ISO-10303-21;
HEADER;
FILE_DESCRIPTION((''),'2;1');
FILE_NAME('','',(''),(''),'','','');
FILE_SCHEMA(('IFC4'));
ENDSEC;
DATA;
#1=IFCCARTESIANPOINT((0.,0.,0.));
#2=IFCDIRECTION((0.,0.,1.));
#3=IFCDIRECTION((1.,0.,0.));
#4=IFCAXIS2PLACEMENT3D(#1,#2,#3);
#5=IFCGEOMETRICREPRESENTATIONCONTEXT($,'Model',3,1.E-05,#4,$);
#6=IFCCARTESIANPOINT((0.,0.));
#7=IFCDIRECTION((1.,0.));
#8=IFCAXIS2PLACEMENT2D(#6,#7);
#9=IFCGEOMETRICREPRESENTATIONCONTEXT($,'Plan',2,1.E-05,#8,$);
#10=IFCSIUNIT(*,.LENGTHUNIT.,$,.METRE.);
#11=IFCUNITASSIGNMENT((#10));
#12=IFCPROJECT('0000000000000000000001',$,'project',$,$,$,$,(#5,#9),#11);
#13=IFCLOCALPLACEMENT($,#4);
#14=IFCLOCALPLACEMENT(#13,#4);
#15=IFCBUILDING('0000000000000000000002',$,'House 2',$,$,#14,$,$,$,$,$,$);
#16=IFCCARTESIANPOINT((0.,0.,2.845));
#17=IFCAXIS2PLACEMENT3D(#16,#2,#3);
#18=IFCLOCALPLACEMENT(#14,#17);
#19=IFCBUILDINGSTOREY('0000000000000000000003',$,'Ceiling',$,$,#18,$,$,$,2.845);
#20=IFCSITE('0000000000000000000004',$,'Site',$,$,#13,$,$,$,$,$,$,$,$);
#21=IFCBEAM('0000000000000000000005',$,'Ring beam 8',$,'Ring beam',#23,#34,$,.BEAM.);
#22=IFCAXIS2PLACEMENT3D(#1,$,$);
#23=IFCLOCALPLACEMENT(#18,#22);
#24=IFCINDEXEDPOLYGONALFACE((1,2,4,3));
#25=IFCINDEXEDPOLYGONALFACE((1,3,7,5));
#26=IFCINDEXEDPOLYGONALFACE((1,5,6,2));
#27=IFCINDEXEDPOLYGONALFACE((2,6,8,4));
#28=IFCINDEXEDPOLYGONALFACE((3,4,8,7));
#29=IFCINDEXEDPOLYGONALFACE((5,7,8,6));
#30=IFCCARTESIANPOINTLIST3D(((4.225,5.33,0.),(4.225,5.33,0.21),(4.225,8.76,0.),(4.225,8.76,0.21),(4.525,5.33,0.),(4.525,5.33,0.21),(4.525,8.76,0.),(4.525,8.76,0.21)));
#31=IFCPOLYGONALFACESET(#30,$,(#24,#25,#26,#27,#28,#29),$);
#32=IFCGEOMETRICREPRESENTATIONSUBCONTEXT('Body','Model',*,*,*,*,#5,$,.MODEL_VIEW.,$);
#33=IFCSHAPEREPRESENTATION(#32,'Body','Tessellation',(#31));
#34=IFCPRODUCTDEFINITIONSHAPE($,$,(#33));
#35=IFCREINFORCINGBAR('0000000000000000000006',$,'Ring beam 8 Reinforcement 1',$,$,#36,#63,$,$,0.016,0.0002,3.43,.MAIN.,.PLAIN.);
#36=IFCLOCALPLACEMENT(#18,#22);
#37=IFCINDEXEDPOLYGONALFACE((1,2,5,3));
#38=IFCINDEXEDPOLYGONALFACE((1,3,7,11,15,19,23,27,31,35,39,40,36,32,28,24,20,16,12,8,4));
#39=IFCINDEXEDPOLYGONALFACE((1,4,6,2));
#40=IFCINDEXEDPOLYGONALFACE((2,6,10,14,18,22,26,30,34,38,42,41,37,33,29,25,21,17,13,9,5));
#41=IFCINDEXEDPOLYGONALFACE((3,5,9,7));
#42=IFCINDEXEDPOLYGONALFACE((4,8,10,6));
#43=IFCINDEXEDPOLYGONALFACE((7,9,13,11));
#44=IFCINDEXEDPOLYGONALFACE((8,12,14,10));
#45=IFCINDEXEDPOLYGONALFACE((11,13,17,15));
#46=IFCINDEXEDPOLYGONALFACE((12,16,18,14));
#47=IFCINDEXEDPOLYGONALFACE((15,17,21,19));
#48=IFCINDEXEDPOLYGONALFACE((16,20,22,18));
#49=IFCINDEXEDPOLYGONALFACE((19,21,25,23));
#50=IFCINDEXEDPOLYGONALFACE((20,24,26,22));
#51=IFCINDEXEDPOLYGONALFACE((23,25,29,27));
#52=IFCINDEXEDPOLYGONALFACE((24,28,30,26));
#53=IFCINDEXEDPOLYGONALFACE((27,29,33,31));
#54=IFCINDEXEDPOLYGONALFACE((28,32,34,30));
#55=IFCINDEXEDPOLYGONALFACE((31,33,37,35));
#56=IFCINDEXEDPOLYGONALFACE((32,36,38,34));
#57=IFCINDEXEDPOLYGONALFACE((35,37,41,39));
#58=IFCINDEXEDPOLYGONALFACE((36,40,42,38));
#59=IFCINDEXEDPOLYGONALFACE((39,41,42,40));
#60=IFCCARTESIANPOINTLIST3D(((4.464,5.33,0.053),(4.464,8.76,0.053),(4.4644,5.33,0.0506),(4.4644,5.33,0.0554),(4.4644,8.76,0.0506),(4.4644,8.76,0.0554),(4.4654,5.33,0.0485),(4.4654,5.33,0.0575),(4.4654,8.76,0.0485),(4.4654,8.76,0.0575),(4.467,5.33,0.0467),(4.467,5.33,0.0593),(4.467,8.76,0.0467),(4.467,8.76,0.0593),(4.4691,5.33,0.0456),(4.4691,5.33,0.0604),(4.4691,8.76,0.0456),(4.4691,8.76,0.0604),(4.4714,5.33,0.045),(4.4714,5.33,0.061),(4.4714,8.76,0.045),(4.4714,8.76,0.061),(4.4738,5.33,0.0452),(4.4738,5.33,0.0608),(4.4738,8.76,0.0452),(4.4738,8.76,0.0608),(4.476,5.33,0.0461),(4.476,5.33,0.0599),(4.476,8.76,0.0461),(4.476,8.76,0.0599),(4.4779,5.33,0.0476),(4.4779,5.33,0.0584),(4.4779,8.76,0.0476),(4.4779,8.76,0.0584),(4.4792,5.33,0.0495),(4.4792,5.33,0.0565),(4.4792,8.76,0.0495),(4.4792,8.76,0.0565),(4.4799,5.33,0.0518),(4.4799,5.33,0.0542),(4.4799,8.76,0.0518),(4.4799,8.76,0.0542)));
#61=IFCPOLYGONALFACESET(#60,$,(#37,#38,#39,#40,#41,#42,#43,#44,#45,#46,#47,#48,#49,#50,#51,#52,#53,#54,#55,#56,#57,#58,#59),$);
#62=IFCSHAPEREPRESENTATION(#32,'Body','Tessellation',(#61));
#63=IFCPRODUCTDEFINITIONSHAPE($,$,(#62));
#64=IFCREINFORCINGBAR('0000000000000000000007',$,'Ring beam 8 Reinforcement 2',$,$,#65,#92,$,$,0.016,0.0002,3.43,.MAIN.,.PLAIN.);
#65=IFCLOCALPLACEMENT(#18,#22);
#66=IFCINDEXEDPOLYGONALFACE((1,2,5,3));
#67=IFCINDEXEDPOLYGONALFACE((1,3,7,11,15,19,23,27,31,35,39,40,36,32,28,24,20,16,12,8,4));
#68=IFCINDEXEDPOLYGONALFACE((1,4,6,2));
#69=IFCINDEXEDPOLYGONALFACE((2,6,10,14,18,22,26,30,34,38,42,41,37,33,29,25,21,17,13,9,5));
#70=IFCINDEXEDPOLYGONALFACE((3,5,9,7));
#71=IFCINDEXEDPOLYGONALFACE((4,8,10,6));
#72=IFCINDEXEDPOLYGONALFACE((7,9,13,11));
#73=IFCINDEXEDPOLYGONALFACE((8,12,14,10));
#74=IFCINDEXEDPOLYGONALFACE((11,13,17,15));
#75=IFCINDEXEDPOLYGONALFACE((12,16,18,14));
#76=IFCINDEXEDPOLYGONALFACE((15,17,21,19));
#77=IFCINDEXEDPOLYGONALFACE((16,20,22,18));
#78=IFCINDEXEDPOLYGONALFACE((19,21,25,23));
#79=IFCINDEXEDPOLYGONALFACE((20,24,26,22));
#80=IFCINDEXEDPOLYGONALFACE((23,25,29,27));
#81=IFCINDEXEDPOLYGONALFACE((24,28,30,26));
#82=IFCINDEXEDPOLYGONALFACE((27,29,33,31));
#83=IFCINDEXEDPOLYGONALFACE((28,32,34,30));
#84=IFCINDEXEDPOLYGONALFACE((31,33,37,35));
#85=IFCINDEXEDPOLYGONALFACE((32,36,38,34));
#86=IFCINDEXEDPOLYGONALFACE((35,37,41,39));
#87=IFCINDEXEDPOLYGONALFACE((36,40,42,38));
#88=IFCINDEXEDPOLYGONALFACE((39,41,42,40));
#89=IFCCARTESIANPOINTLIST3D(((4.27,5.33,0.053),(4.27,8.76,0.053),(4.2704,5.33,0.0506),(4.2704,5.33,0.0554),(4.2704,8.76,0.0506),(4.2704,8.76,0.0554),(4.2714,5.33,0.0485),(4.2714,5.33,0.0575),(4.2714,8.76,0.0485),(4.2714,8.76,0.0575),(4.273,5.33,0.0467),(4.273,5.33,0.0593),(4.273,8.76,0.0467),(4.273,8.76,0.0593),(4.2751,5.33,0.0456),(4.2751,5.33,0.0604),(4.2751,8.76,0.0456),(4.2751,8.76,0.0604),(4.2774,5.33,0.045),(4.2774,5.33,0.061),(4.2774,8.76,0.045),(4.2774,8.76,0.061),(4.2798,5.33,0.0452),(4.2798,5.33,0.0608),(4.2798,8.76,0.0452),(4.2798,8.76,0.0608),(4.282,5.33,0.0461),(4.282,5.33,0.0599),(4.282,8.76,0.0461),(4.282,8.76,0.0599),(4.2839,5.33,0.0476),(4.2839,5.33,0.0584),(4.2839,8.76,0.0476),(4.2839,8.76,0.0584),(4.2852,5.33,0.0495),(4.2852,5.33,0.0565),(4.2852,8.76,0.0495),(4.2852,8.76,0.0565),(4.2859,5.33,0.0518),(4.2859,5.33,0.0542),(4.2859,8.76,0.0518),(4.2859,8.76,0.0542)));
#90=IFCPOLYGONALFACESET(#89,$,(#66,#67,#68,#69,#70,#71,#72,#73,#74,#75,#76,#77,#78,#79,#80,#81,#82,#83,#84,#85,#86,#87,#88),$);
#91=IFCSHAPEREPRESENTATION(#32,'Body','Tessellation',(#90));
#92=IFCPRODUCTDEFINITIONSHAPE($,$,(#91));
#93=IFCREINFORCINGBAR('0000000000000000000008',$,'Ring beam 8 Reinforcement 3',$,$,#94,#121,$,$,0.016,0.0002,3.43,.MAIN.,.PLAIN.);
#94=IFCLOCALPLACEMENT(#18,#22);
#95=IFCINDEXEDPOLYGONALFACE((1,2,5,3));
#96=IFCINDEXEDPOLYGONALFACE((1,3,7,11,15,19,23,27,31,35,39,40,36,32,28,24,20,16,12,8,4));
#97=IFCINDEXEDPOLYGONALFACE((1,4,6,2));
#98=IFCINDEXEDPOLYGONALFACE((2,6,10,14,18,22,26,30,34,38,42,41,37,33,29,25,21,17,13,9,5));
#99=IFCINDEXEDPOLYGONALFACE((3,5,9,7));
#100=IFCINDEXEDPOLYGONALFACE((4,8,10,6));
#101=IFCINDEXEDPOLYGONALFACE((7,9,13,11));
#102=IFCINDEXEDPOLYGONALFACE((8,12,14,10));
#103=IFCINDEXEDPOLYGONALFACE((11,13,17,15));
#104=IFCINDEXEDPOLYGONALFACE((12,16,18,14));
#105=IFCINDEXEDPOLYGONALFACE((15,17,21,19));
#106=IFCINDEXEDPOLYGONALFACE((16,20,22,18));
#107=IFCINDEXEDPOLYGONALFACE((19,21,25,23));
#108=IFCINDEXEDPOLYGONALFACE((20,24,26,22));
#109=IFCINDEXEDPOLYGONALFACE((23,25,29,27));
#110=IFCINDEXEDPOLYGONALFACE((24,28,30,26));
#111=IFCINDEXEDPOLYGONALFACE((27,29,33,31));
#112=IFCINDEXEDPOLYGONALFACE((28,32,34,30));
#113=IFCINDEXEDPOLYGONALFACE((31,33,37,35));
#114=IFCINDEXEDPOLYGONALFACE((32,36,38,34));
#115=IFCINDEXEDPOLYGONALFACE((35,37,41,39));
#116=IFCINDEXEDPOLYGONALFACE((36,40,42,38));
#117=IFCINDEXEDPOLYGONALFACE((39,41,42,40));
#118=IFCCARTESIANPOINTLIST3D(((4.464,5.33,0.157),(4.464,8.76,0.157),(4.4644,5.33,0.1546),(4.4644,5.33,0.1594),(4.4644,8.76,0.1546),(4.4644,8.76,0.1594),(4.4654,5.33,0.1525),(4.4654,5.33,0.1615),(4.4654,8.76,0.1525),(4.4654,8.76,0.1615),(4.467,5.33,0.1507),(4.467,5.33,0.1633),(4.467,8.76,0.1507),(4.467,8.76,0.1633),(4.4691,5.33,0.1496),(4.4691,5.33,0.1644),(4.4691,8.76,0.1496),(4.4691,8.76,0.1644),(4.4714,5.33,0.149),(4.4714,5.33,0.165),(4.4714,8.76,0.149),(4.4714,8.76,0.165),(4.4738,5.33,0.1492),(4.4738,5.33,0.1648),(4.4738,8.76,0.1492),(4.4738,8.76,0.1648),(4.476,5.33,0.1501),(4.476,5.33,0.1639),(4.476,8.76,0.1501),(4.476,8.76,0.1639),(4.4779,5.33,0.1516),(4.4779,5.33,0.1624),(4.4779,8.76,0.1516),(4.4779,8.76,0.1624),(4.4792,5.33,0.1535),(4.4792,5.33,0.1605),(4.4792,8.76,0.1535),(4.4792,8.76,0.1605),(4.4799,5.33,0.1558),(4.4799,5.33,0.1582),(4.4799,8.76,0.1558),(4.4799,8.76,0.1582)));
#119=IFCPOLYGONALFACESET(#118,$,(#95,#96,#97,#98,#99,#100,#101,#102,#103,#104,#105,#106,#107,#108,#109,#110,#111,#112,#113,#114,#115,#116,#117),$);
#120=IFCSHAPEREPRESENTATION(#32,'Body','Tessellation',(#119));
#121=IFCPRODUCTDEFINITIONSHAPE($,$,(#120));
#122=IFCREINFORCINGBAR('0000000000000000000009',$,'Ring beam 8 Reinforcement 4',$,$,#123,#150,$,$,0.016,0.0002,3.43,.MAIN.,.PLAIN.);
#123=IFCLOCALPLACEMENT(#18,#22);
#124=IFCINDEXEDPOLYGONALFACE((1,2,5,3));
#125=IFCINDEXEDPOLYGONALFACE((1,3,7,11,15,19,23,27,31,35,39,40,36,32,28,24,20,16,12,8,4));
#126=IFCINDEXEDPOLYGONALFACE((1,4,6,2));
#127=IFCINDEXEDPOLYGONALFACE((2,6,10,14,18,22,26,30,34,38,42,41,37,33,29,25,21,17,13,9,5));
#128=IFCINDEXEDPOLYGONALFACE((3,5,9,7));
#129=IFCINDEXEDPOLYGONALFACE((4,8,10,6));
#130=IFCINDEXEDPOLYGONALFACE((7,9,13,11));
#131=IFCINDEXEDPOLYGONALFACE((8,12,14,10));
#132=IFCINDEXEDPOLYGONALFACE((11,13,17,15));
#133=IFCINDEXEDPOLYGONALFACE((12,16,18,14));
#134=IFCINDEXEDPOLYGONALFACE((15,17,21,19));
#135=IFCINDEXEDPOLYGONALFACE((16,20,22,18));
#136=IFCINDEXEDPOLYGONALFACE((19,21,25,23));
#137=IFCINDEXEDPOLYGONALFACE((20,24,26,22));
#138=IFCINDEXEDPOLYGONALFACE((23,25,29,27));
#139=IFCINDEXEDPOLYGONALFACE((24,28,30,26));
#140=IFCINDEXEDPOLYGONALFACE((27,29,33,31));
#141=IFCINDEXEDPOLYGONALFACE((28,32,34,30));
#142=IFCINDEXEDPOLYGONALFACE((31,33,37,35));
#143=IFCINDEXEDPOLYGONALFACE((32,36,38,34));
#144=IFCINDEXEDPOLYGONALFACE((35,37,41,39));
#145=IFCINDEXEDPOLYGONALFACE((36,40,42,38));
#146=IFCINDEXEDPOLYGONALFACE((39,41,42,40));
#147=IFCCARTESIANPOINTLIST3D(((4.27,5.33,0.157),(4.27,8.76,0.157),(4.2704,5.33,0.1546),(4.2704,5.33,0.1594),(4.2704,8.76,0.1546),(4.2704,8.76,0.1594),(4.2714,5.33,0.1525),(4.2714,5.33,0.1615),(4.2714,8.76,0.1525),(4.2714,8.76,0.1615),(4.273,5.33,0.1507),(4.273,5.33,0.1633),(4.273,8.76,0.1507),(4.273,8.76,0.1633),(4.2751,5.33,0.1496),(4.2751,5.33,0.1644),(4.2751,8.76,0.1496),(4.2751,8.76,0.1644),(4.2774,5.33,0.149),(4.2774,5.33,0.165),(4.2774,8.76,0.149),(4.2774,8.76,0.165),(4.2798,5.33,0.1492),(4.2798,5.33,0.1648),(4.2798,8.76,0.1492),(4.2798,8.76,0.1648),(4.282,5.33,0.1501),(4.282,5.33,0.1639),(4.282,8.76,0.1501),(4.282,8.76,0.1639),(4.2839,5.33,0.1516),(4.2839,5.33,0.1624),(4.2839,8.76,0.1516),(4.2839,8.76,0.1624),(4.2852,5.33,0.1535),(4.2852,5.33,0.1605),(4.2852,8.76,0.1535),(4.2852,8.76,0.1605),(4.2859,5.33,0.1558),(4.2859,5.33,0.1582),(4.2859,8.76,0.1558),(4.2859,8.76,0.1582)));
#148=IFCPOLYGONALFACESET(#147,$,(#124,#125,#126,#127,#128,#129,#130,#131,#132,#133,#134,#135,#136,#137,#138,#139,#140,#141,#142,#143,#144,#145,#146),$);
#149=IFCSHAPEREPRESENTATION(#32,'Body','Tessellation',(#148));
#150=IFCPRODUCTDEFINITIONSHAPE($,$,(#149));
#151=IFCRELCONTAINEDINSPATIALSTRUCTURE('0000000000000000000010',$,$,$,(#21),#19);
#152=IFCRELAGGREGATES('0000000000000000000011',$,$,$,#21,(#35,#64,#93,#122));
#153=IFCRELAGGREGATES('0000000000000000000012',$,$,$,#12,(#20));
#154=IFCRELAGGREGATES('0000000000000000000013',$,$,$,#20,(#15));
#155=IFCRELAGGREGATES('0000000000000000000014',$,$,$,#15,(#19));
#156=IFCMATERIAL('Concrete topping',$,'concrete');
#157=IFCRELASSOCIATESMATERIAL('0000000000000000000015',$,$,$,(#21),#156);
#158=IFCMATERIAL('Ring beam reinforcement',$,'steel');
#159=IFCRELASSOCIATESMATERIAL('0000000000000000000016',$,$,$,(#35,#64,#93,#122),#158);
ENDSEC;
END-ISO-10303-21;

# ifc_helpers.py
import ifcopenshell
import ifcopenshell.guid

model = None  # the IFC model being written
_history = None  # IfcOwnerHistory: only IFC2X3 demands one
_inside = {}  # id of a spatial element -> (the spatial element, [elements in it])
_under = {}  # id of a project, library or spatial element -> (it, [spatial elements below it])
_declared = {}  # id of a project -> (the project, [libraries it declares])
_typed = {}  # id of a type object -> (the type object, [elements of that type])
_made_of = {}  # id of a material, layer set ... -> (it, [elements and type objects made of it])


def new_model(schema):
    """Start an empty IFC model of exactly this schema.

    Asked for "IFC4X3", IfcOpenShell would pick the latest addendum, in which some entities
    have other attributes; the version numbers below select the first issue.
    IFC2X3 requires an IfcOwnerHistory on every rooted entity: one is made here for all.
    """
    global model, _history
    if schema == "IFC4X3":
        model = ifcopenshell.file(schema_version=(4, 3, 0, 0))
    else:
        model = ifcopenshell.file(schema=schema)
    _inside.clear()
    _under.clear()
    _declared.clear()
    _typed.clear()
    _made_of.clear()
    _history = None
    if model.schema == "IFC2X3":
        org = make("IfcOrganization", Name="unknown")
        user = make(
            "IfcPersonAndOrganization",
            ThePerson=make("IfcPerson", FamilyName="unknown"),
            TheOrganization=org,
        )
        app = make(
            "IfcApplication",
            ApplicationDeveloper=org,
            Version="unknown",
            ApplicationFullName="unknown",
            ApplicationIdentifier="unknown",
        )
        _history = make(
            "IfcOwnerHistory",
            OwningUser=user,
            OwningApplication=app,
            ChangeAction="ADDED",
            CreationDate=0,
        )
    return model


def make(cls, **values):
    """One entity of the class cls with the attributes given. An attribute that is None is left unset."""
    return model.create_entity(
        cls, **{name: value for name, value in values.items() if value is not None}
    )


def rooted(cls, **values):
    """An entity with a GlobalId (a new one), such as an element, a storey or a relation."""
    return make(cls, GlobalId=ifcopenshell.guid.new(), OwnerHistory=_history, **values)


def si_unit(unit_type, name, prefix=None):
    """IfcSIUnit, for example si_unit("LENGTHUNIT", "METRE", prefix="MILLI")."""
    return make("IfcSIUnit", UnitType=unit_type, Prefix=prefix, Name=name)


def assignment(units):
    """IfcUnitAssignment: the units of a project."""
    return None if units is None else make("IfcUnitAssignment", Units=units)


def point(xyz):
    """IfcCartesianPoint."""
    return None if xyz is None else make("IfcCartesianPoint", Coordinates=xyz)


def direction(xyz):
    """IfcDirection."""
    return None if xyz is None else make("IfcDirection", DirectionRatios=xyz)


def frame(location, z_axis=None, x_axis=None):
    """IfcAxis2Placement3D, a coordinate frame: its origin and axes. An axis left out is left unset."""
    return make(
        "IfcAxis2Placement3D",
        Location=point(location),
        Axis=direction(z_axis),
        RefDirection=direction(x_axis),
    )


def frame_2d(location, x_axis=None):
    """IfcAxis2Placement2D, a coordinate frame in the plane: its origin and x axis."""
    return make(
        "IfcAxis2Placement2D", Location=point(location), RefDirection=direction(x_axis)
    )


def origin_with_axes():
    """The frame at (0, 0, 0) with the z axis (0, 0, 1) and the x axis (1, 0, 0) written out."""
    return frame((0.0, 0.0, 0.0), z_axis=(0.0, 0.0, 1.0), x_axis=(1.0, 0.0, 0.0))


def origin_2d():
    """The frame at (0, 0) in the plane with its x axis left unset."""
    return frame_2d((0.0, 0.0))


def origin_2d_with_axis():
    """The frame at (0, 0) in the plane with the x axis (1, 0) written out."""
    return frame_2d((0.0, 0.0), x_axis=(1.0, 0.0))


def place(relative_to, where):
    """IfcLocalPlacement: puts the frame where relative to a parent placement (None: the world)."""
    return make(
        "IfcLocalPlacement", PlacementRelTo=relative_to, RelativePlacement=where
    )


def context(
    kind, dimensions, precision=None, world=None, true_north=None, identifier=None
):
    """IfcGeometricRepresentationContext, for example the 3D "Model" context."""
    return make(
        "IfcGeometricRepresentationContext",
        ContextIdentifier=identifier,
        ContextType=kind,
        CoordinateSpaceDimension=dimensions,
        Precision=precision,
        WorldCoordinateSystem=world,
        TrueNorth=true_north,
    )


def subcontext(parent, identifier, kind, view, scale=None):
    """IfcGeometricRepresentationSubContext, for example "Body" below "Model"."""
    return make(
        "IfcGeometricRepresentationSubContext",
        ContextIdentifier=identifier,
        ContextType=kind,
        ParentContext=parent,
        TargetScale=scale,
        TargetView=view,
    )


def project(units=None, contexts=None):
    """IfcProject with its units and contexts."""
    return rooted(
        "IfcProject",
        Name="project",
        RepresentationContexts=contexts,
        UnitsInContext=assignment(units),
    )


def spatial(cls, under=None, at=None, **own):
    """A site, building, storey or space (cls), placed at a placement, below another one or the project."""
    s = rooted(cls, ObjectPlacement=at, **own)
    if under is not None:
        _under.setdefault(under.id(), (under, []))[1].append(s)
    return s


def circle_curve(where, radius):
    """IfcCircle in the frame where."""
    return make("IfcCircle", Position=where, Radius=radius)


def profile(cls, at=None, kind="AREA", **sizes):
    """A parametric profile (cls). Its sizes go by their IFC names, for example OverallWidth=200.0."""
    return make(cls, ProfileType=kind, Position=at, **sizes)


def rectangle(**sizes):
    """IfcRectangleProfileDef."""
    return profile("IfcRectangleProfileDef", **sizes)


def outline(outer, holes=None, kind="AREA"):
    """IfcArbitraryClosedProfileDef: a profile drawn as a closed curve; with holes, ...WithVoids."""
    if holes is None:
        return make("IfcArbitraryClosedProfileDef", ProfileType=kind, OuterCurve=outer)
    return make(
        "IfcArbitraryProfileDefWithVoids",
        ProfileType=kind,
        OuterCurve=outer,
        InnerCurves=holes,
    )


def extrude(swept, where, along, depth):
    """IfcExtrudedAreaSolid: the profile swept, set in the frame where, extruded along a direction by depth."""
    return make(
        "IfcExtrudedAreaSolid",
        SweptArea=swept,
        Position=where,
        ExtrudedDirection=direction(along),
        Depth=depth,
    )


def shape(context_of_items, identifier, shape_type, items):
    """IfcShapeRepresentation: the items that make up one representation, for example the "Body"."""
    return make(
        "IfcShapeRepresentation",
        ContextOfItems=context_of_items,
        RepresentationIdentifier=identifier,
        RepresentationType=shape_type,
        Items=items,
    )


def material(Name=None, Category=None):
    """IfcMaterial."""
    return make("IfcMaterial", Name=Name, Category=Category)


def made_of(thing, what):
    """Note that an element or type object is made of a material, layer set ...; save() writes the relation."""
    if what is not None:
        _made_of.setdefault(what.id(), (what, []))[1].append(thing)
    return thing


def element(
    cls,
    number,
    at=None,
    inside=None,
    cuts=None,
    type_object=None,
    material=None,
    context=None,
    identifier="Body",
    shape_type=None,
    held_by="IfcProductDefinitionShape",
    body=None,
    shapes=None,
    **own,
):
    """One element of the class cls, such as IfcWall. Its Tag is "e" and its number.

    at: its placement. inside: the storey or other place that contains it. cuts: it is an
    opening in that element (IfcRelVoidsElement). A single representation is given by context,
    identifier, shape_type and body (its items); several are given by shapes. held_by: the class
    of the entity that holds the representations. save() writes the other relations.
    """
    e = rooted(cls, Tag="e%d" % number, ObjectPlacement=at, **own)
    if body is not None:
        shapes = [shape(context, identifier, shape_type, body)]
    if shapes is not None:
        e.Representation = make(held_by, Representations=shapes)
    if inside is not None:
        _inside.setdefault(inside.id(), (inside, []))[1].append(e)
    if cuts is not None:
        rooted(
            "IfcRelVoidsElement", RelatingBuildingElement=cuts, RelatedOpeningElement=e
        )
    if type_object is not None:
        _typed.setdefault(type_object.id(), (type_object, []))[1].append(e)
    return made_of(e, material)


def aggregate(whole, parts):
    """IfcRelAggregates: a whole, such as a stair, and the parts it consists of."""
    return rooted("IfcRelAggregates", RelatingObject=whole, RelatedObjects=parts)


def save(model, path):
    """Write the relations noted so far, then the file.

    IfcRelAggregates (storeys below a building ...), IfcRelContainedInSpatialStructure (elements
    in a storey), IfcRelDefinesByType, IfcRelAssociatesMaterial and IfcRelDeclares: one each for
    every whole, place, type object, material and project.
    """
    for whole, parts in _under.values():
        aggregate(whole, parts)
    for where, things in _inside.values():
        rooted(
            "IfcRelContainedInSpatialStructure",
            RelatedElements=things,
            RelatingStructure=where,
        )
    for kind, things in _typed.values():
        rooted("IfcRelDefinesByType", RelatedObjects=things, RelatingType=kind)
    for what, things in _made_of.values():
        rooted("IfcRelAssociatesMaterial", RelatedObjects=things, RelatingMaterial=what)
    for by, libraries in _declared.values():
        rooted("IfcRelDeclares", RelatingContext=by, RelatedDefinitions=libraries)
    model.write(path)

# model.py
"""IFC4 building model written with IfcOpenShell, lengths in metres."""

from ifc_helpers import new_model, si_unit, frame, origin_with_axes, origin_2d, origin_2d_with_axis, place, context, subcontext, project, spatial, circle_curve, rectangle, outline, extrude, material, element, aggregate, save


model = new_model("IFC4")

# Units and contexts
model_context = context("Model", 3, precision=1e-05, world=origin_with_axes())
plan_context = context("Plan", 2, precision=1e-05, world=origin_2d_with_axis())
body_context_1 = subcontext(model_context, "Body", "Model", "MODEL_VIEW")
ifc_project = project(units=[si_unit("LENGTHUNIT", "METRE")], contexts=[model_context, plan_context])

# Site, building, storey
site_placement = place(None, origin_with_axes())
building_placement = place(site_placement, origin_with_axes())
storey_placement = place(building_placement, frame((0.0, 0.0, 2.845), z_axis=(0.0, 0.0, 1.0), x_axis=(1.0, 0.0, 0.0)))
site = spatial("IfcSite", under=ifc_project, at=site_placement, Name="Site")
building = spatial("IfcBuilding", under=site, at=building_placement, Name="House 2")
storey = spatial("IfcBuildingStorey", under=building, at=storey_placement, Name="Ceiling", Elevation=2.845)

# Beam
ifc_material_1 = material(Name="Concrete topping", Category="concrete")
beam_1_placement = place(storey_placement, frame((4.375, 5.33, 0.105), z_axis=(0.0, 0.0, 1.0), x_axis=(0.0, 1.0, 0.0)))
beam_1 = element("IfcBeam", 1, at=beam_1_placement, inside=storey, material=ifc_material_1, Name="Ring beam 8", ObjectType="Ring beam", PredefinedType="BEAM", context=body_context_1, shape_type="SweptSolid", body=[
    extrude(rectangle(XDim=0.3, YDim=0.21), frame((0.0, 0.0, 0.0), z_axis=(1.0, 0.0, 0.0), x_axis=(0.0, 1.0, 0.0)), (0.0, 0.0, 1.0), 3.43),
])

# Reinforcing bars
ifc_material_2 = material(Name="Ring beam reinforcement", Category="steel")
reinforcing_bar_1_placement = place(beam_1_placement, frame((0.0, -0.097, -0.052), z_axis=(0.0, 0.0, 1.0), x_axis=(1.0, 0.0, 0.0)))
reinforcing_bar_1 = element("IfcReinforcingBar", 2, at=reinforcing_bar_1_placement, material=ifc_material_2, Name="Ring beam 8 Reinforcement 1", BarLength=3.43, BarSurface="PLAIN", CrossSectionArea=0.0002, NominalDiameter=0.016, PredefinedType="MAIN", context=body_context_1, shape_type="SweptSolid", body=[
    extrude(outline(circle_curve(origin_2d(), 0.008)), frame((0.0, 0.0, 0.0), z_axis=(1.0, 0.0, 0.0), x_axis=(0.0, 1.0, 0.0)), (0.0, 0.0, 1.0), 3.43),
])
reinforcing_bar_2_placement = place(beam_1_placement, frame((0.0, 0.097, -0.052), z_axis=(0.0, 0.0, 1.0), x_axis=(1.0, 0.0, 0.0)))
reinforcing_bar_2 = element("IfcReinforcingBar", 3, at=reinforcing_bar_2_placement, material=ifc_material_2, Name="Ring beam 8 Reinforcement 2", BarLength=3.43, BarSurface="PLAIN", CrossSectionArea=0.0002, NominalDiameter=0.016, PredefinedType="MAIN", context=body_context_1, shape_type="SweptSolid", body=[
    extrude(outline(circle_curve(origin_2d(), 0.008)), frame((0.0, 0.0, 0.0), z_axis=(1.0, 0.0, 0.0), x_axis=(0.0, 1.0, 0.0)), (0.0, 0.0, 1.0), 3.43),
])
reinforcing_bar_3_placement = place(beam_1_placement, frame((0.0, -0.097, 0.052), z_axis=(0.0, 0.0, 1.0), x_axis=(1.0, 0.0, 0.0)))
reinforcing_bar_3 = element("IfcReinforcingBar", 4, at=reinforcing_bar_3_placement, material=ifc_material_2, Name="Ring beam 8 Reinforcement 3", BarLength=3.43, BarSurface="PLAIN", CrossSectionArea=0.0002, NominalDiameter=0.016, PredefinedType="MAIN", context=body_context_1, shape_type="SweptSolid", body=[
    extrude(outline(circle_curve(origin_2d(), 0.008)), frame((0.0, 0.0, 0.0), z_axis=(1.0, 0.0, 0.0), x_axis=(0.0, 1.0, 0.0)), (0.0, 0.0, 1.0), 3.43),
])
reinforcing_bar_4_placement = place(beam_1_placement, frame((0.0, 0.097, 0.052), z_axis=(0.0, 0.0, 1.0), x_axis=(1.0, 0.0, 0.0)))
reinforcing_bar_4 = element("IfcReinforcingBar", 5, at=reinforcing_bar_4_placement, material=ifc_material_2, Name="Ring beam 8 Reinforcement 4", BarLength=3.43, BarSurface="PLAIN", CrossSectionArea=0.0002, NominalDiameter=0.016, PredefinedType="MAIN", context=body_context_1, shape_type="SweptSolid", body=[
    extrude(outline(circle_curve(origin_2d(), 0.008)), frame((0.0, 0.0, 0.0), z_axis=(1.0, 0.0, 0.0), x_axis=(0.0, 1.0, 0.0)), (0.0, 0.0, 1.0), 3.43),
])
aggregate(beam_1, [reinforcing_bar_1, reinforcing_bar_2, reinforcing_bar_3, reinforcing_bar_4])

save(model, "model.ifc")
